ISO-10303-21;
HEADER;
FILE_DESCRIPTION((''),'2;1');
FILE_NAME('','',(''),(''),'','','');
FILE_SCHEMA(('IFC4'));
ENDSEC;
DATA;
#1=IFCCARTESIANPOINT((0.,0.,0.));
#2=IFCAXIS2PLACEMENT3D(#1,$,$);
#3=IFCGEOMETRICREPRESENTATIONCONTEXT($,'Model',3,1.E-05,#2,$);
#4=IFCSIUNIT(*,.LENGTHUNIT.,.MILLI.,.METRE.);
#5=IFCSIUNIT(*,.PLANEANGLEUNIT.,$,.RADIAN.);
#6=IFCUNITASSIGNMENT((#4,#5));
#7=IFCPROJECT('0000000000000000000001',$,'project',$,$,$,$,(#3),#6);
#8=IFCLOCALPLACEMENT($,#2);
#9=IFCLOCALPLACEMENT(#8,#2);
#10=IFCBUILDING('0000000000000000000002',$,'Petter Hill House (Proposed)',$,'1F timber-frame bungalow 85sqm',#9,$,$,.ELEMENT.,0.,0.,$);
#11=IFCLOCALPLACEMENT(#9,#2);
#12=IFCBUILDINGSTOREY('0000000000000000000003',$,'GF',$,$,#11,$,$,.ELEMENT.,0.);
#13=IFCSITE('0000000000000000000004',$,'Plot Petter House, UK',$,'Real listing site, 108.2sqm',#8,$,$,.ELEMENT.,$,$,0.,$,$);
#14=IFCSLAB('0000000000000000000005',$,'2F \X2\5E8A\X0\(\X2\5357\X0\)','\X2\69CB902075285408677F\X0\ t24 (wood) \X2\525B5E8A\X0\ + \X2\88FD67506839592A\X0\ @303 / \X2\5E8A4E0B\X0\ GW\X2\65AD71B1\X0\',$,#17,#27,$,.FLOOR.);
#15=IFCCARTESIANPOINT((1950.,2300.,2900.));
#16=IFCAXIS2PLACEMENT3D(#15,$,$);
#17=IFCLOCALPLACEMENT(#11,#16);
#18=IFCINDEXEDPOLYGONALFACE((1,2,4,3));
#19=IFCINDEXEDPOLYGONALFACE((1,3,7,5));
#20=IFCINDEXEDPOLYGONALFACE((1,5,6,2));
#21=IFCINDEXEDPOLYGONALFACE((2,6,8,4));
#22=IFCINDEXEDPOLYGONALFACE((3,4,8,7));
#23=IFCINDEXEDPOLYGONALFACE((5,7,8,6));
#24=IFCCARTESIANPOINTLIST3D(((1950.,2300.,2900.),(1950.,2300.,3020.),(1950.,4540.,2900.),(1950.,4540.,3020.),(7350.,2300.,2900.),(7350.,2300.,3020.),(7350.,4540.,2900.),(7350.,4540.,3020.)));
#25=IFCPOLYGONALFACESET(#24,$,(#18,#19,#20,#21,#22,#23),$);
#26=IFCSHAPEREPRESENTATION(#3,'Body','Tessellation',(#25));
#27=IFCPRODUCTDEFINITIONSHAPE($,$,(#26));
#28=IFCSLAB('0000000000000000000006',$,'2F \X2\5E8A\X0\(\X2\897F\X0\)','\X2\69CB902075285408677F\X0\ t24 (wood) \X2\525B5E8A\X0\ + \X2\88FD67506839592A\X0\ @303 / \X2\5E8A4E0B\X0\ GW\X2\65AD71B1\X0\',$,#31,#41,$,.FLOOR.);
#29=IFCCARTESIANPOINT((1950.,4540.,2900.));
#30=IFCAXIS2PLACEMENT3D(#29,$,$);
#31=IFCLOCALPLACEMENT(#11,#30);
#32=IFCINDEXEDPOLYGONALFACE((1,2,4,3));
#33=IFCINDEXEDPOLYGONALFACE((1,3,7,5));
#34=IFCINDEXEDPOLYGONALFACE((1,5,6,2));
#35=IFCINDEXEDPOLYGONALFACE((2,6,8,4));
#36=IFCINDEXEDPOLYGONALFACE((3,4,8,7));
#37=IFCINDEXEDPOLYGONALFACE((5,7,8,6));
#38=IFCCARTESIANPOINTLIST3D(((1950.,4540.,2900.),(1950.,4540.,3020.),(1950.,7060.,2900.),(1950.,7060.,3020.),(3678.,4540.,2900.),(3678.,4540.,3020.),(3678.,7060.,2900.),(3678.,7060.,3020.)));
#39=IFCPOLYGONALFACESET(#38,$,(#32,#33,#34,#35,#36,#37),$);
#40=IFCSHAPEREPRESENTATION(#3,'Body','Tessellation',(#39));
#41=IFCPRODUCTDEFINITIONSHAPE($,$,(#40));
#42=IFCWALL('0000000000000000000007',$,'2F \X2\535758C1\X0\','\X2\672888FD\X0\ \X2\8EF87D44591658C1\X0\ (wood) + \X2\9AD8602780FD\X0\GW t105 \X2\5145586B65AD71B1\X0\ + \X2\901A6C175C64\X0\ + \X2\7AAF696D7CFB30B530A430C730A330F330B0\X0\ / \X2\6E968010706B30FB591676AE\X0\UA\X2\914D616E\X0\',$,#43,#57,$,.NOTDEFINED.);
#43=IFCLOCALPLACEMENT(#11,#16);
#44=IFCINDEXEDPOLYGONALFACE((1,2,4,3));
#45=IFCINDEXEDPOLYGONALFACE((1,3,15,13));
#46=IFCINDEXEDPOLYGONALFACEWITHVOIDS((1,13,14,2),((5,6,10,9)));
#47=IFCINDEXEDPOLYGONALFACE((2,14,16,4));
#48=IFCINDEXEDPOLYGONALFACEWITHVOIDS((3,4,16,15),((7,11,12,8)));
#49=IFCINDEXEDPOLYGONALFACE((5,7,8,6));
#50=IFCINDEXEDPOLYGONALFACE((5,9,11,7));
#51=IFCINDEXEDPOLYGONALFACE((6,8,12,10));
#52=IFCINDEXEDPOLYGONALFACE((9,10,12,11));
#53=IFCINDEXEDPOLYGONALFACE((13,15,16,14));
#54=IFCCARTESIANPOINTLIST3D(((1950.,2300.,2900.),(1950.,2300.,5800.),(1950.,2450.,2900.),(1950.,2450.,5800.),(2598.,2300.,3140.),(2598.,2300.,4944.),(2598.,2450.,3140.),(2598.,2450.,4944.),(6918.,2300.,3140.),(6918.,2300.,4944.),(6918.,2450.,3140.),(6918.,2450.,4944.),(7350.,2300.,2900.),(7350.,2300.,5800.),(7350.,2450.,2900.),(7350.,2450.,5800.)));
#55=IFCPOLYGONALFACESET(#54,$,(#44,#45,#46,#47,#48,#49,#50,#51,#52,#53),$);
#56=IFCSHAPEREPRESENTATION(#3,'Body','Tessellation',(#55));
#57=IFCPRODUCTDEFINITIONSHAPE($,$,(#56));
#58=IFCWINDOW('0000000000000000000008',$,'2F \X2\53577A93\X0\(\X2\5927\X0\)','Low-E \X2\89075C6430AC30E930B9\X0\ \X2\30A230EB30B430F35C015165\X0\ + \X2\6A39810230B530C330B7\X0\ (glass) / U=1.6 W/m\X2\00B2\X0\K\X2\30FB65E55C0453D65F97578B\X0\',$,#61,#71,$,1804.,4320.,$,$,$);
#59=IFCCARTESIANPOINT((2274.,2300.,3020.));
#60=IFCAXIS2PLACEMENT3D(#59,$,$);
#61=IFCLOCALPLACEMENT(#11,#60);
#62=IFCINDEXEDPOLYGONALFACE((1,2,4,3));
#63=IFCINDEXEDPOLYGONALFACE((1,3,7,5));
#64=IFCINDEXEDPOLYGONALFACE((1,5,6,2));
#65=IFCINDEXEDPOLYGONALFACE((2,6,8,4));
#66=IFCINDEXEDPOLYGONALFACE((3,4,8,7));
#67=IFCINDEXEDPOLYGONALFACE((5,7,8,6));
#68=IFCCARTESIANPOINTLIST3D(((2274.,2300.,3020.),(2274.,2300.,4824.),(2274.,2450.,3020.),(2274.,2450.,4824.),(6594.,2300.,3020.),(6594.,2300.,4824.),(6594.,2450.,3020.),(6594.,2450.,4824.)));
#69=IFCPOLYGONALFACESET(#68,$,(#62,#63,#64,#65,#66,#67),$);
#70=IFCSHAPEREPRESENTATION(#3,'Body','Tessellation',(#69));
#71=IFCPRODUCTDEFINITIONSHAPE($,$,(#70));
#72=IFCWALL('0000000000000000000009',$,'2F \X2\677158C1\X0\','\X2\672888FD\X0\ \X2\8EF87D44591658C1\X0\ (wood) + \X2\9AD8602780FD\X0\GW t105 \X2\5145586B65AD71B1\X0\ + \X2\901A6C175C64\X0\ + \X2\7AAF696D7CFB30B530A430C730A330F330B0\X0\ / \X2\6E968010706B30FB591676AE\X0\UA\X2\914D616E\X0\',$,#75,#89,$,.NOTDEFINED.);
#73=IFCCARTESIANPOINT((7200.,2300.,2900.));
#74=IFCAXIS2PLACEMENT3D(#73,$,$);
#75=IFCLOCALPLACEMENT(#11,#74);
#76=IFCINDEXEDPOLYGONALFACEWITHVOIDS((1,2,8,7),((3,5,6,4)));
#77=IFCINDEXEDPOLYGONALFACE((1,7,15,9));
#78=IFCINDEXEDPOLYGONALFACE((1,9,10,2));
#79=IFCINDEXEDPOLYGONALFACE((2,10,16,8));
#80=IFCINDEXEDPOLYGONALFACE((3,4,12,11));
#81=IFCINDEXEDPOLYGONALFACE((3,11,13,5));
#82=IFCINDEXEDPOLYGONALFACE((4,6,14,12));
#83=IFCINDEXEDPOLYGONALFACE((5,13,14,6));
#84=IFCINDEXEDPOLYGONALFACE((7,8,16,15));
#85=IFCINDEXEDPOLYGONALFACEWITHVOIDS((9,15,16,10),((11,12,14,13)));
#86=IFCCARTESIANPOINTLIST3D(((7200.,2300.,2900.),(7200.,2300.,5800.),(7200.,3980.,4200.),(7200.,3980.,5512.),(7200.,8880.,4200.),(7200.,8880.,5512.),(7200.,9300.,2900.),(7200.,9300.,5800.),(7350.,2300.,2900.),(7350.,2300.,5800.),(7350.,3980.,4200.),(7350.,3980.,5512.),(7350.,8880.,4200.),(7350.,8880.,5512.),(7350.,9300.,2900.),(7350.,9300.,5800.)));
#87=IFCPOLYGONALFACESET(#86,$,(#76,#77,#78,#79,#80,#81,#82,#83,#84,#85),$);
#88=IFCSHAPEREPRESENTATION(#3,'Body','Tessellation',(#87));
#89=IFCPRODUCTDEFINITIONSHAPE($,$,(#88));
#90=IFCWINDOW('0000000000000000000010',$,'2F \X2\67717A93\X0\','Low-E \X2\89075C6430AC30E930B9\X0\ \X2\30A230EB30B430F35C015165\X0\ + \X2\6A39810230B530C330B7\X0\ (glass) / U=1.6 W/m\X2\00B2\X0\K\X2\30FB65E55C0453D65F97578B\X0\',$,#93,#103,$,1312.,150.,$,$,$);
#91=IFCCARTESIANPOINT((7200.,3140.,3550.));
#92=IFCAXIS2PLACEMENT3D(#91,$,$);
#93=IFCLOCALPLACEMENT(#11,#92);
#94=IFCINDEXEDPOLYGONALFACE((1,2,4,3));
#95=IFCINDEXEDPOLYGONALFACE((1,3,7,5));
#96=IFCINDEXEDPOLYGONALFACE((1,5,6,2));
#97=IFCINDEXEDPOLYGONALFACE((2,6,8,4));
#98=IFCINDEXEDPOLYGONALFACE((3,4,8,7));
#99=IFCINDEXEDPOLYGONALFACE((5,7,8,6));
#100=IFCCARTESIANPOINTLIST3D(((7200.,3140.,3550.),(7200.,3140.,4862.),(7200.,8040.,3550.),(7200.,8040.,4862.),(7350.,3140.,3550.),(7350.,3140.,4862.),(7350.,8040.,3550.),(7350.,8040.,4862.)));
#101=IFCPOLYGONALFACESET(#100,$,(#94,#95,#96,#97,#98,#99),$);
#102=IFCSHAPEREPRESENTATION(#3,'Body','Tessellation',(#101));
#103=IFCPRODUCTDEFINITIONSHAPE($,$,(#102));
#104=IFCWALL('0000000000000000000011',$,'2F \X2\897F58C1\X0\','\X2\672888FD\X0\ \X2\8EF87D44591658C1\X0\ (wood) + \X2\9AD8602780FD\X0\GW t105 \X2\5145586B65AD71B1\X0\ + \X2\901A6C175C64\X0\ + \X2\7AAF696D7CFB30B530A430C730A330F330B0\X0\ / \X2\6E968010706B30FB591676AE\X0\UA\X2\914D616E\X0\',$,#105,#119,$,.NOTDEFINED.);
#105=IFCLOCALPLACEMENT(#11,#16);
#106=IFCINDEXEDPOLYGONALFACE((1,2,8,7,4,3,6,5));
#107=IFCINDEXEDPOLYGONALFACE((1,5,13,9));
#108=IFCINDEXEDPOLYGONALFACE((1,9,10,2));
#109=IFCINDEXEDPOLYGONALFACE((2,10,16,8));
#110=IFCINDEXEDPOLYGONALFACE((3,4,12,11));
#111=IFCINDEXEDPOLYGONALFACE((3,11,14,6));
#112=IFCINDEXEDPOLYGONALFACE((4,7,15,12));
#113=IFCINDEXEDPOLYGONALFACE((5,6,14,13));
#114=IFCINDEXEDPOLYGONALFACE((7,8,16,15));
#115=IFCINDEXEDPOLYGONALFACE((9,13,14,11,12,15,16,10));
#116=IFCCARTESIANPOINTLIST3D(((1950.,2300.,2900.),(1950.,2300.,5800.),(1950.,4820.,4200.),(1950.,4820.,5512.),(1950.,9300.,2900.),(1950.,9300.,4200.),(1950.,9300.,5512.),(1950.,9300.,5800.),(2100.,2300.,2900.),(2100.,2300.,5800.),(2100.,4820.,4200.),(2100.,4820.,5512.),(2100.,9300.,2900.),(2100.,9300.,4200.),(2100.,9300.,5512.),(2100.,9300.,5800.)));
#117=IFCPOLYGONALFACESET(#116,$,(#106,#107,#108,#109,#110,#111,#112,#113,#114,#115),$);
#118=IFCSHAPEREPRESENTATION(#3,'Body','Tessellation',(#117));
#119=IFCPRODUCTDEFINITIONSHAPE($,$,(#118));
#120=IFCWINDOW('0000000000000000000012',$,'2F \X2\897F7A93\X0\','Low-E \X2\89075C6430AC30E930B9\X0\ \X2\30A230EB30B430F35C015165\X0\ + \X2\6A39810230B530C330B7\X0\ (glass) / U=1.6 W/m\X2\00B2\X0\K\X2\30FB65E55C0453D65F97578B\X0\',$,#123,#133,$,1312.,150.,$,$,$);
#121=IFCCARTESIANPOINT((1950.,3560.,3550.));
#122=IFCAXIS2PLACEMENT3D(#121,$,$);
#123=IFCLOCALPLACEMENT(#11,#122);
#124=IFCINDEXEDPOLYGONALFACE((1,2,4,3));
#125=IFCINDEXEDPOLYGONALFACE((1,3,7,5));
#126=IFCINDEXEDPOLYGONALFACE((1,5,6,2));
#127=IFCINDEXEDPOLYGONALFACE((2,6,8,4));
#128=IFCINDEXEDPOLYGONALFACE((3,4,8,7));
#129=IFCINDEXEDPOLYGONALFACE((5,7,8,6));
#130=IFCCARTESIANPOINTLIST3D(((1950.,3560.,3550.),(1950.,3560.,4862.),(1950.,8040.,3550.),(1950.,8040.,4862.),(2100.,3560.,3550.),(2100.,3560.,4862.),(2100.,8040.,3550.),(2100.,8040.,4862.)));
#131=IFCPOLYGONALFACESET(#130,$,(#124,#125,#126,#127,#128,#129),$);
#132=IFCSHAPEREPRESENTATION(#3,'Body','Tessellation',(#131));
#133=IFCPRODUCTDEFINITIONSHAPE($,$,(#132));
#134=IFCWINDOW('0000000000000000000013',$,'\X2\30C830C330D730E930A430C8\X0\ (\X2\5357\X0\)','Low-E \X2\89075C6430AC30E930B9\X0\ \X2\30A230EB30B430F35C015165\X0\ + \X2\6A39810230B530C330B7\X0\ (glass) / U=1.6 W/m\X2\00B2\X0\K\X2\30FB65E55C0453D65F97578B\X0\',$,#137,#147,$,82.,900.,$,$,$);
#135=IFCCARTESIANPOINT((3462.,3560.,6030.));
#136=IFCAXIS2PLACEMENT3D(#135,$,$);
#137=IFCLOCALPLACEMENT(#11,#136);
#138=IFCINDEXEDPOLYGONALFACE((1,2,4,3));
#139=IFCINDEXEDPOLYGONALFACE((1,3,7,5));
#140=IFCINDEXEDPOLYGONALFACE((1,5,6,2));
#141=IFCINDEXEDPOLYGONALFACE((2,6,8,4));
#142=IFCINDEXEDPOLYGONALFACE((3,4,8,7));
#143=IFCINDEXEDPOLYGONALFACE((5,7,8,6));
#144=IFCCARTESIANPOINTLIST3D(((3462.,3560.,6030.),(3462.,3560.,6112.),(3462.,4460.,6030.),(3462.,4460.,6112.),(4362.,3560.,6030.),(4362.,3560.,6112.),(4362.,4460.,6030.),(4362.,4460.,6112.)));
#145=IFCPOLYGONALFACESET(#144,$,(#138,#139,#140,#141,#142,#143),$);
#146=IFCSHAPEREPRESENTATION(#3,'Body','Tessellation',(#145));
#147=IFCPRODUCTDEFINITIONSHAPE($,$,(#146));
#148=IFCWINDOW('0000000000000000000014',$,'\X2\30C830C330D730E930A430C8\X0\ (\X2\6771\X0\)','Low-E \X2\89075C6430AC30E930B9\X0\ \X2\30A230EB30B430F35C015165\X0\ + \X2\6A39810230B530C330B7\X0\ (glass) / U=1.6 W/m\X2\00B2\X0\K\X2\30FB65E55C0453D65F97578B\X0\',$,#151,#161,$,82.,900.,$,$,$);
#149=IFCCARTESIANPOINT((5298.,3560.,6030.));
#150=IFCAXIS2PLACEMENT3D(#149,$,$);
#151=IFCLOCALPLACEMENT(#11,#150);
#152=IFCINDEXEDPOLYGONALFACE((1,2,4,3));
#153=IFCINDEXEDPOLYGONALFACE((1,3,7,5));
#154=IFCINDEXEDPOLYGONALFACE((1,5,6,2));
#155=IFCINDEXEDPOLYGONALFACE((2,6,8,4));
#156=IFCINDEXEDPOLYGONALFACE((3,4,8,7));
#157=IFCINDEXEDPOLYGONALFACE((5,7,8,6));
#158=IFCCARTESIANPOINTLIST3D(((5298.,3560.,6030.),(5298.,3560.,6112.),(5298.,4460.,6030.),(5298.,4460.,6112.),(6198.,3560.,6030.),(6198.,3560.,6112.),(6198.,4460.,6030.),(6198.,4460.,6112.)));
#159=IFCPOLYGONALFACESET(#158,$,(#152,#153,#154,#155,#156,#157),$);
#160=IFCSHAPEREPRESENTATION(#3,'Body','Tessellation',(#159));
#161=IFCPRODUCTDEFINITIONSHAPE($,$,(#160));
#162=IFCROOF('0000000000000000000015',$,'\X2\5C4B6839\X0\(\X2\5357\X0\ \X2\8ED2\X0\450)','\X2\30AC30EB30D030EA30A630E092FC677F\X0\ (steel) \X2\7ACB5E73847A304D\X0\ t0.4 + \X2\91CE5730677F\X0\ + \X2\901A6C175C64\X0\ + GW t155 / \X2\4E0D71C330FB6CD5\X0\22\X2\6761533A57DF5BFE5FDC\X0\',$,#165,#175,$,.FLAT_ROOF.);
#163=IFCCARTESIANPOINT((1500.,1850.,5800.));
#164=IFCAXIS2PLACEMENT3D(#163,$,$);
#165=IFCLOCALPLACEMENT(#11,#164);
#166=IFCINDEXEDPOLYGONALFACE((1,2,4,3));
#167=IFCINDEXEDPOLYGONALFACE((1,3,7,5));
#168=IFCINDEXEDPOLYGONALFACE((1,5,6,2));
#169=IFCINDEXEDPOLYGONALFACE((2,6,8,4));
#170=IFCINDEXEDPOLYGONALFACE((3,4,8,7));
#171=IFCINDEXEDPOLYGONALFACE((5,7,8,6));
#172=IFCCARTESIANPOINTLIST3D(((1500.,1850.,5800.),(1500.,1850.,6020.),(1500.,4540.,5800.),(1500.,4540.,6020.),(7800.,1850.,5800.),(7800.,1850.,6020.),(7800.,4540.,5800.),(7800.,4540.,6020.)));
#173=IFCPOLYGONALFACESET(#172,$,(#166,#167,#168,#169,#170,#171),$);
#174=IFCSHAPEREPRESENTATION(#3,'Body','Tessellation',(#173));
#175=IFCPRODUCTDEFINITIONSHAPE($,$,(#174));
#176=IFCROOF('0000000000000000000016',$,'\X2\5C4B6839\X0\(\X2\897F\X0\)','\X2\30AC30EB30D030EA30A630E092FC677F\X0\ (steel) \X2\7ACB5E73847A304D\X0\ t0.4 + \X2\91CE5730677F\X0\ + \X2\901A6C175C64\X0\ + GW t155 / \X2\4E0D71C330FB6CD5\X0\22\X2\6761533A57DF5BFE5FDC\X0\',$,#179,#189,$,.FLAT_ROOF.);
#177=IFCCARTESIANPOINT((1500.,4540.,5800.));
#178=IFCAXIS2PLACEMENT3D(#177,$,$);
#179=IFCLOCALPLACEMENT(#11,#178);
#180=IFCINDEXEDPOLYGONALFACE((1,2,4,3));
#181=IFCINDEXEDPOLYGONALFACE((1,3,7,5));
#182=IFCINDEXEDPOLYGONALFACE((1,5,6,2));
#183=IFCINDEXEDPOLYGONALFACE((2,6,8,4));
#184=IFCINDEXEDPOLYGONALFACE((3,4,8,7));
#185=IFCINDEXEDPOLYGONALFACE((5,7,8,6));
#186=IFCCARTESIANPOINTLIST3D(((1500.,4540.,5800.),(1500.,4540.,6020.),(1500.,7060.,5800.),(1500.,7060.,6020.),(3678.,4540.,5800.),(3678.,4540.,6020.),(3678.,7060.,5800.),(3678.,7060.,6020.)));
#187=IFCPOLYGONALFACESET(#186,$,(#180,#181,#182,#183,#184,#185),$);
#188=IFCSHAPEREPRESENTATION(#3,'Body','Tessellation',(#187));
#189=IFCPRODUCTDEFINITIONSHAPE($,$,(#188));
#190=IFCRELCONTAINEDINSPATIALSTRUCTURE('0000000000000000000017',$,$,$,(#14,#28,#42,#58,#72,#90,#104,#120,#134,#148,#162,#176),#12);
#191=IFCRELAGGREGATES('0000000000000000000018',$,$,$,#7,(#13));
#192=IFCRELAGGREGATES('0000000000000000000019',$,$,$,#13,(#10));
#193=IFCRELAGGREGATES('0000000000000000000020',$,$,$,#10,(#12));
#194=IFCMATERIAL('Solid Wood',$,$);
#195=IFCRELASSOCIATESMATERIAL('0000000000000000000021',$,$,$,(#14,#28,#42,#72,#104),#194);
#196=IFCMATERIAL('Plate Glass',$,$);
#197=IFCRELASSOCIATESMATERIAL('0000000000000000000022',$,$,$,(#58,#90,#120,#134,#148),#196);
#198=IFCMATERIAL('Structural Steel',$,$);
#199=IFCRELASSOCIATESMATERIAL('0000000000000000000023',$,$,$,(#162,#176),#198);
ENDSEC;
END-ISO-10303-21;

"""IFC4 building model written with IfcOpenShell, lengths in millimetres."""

from ifc_helpers import new_model, si_unit, frame, frame_2d, origin, place, context, project, spatial, rectangle, extrude, material, element, fill, save


model = new_model("IFC4")

# Units and contexts
model_context = context("Model", 3, precision=1e-05, world=origin())
ifc_project = project(units=[si_unit("LENGTHUNIT", "METRE", prefix="MILLI"), si_unit("PLANEANGLEUNIT", "RADIAN")], contexts=[model_context])

# Site, building, storey
site_placement = place(None, origin())
site = spatial("IfcSite", under=ifc_project, at=site_placement, Name="Plot Petter House, UK", ObjectType="Real listing site, 108.2sqm", CompositionType="ELEMENT", RefElevation=0.0)
building_placement = place(site_placement, origin())
building = spatial("IfcBuilding", under=site, at=building_placement, Name="Petter Hill House (Proposed)", ObjectType="1F timber-frame bungalow 85sqm", CompositionType="ELEMENT", ElevationOfRefHeight=0.0, ElevationOfTerrain=0.0)
storey_placement = place(building_placement, origin())
storey = spatial("IfcBuildingStorey", under=building, at=storey_placement, Name="GF", CompositionType="ELEMENT", Elevation=0.0)

# Slabs
ifc_material_1 = material(Name="Solid Wood")
slab_1_placement = place(storey_placement, frame((1950.0, 2300.0, 2900.0)))
element("IfcSlab", 1, at=slab_1_placement, inside=storey, material=ifc_material_1, Name="2F 床(南)", Description="構造用合板 t24 (wood) 剛床 + 製材根太 @303 / 床下 GW断熱", PredefinedType="FLOOR", context=model_context, shape_type="SweptSolid", body=[
    extrude(rectangle(XDim=5400.0, YDim=2240.0, at=frame_2d((2700.0, 1120.0))), frame((1950.0, 2300.0, 2900.0)), (0.0, 0.0, 1.0), 120.0),
])
slab_2_placement = place(storey_placement, frame((1950.0, 4540.0, 2900.0)))
element("IfcSlab", 2, at=slab_2_placement, inside=storey, material=ifc_material_1, Name="2F 床(西)", Description="構造用合板 t24 (wood) 剛床 + 製材根太 @303 / 床下 GW断熱", PredefinedType="FLOOR", context=model_context, shape_type="SweptSolid", body=[
    extrude(rectangle(XDim=1728.0, YDim=2520.0, at=frame_2d((864.0, 1260.0))), frame((1950.0, 4540.0, 2900.0)), (0.0, 0.0, 1.0), 120.0),
])

# Walls, openings, windows
wall_1_placement = place(storey_placement, frame((1950.0, 2300.0, 2900.0)))
wall_1 = element("IfcWall", 3, at=wall_1_placement, inside=storey, material=ifc_material_1, Name="2F 南壁", Description="木製 軸組外壁 (wood) + 高性能GW t105 充填断熱 + 通気層 + 窯業系サイディング / 準耐火・外皮UA配慮", PredefinedType="NOTDEFINED", context=model_context, shape_type="SweptSolid", body=[
    extrude(rectangle(XDim=5400.0, YDim=150.0, at=frame_2d((2700.0, 75.0))), frame((1950.0, 2300.0, 2900.0)), (0.0, 0.0, 1.0), 2900.0),
])
opening_1_placement = place(storey_placement, frame((2274.0, 2300.0, 3020.0)))
opening_1 = element("IfcOpeningElement", 4, at=opening_1_placement, cuts=wall_1, PredefinedType="NOTDEFINED", context=model_context, shape_type="SweptSolid", body=[
    extrude(rectangle(XDim=4320.0, YDim=150.0, at=frame_2d((2160.0, 75.0))), frame((2274.0, 2300.0, 3020.0)), (0.0, 0.0, 1.0), 1804.0),
])
ifc_material_2 = material(Name="Plate Glass")
window_1_placement = place(storey_placement, frame((2274.0, 2300.0, 3020.0)))
window_1 = element("IfcWindow", 5, at=window_1_placement, inside=storey, material=ifc_material_2, Name="2F 南窓(大)", Description="Low-E 複層ガラス アルゴン封入 + 樹脂サッシ (glass) / U=1.6 W/m²K・日射取得型", OverallHeight=1804.0, OverallWidth=4320.0, context=model_context, shape_type="SweptSolid", body=[
    extrude(rectangle(XDim=4320.0, YDim=150.0, at=frame_2d((2160.0, 75.0))), frame((2274.0, 2300.0, 3020.0)), (0.0, 0.0, 1.0), 1804.0),
])
fill(opening_1, window_1)
wall_2_placement = place(storey_placement, frame((7200.0, 2300.0, 2900.0)))
wall_2 = element("IfcWall", 6, at=wall_2_placement, inside=storey, material=ifc_material_1, Name="2F 東壁", Description="木製 軸組外壁 (wood) + 高性能GW t105 充填断熱 + 通気層 + 窯業系サイディング / 準耐火・外皮UA配慮", PredefinedType="NOTDEFINED", context=model_context, shape_type="SweptSolid", body=[
    extrude(rectangle(XDim=150.0, YDim=7000.0, at=frame_2d((75.0, 3500.0))), frame((7200.0, 2300.0, 2900.0)), (0.0, 0.0, 1.0), 2900.0),
])
opening_2_placement = place(storey_placement, frame((7200.0, 3140.0, 3550.0)))
opening_2 = element("IfcOpeningElement", 7, at=opening_2_placement, cuts=wall_2, PredefinedType="NOTDEFINED", context=model_context, shape_type="SweptSolid", body=[
    extrude(rectangle(XDim=150.0, YDim=4900.0, at=frame_2d((75.0, 2450.0))), frame((7200.0, 3140.0, 3550.0)), (0.0, 0.0, 1.0), 1312.0),
])
window_2_placement = place(storey_placement, frame((7200.0, 3140.0, 3550.0)))
window_2 = element("IfcWindow", 8, at=window_2_placement, inside=storey, material=ifc_material_2, Name="2F 東窓", Description="Low-E 複層ガラス アルゴン封入 + 樹脂サッシ (glass) / U=1.6 W/m²K・日射取得型", OverallHeight=1312.0, OverallWidth=150.0, context=model_context, shape_type="SweptSolid", body=[
    extrude(rectangle(XDim=150.0, YDim=4900.0, at=frame_2d((75.0, 2450.0))), frame((7200.0, 3140.0, 3550.0)), (0.0, 0.0, 1.0), 1312.0),
])
fill(opening_2, window_2)
wall_3_placement = place(storey_placement, frame((1950.0, 2300.0, 2900.0)))
wall_3 = element("IfcWall", 9, at=wall_3_placement, inside=storey, material=ifc_material_1, Name="2F 西壁", Description="木製 軸組外壁 (wood) + 高性能GW t105 充填断熱 + 通気層 + 窯業系サイディング / 準耐火・外皮UA配慮", PredefinedType="NOTDEFINED", context=model_context, shape_type="SweptSolid", body=[
    extrude(rectangle(XDim=150.0, YDim=7000.0, at=frame_2d((75.0, 3500.0))), frame((1950.0, 2300.0, 2900.0)), (0.0, 0.0, 1.0), 2900.0),
])
opening_3_placement = place(storey_placement, frame((1950.0, 3560.0, 3550.0)))
opening_3 = element("IfcOpeningElement", 10, at=opening_3_placement, cuts=wall_3, PredefinedType="NOTDEFINED", context=model_context, shape_type="SweptSolid", body=[
    extrude(rectangle(XDim=150.0, YDim=4480.0, at=frame_2d((75.0, 2240.0))), frame((1950.0, 3560.0, 3550.0)), (0.0, 0.0, 1.0), 1312.0),
])
window_3_placement = place(storey_placement, frame((1950.0, 3560.0, 3550.0)))
window_3 = element("IfcWindow", 11, at=window_3_placement, inside=storey, material=ifc_material_2, Name="2F 西窓", Description="Low-E 複層ガラス アルゴン封入 + 樹脂サッシ (glass) / U=1.6 W/m²K・日射取得型", OverallHeight=1312.0, OverallWidth=150.0, context=model_context, shape_type="SweptSolid", body=[
    extrude(rectangle(XDim=150.0, YDim=4480.0, at=frame_2d((75.0, 2240.0))), frame((1950.0, 3560.0, 3550.0)), (0.0, 0.0, 1.0), 1312.0),
])
fill(opening_3, window_3)

# Windows
window_4_placement = place(storey_placement, frame((3462.0, 3560.0, 6030.0)))
element("IfcWindow", 12, at=window_4_placement, inside=storey, material=ifc_material_2, Name="トップライト (南)", Description="Low-E 複層ガラス アルゴン封入 + 樹脂サッシ (glass) / U=1.6 W/m²K・日射取得型", OverallHeight=82.0, OverallWidth=900.0, context=model_context, shape_type="SweptSolid", body=[
    extrude(rectangle(XDim=900.0, YDim=900.0, at=frame_2d((450.0, 450.0))), frame((3462.0, 3560.0, 6030.0)), (0.0, 0.0, 1.0), 82.0),
])
window_5_placement = place(storey_placement, frame((5298.0, 3560.0, 6030.0)))
element("IfcWindow", 13, at=window_5_placement, inside=storey, material=ifc_material_2, Name="トップライト (東)", Description="Low-E 複層ガラス アルゴン封入 + 樹脂サッシ (glass) / U=1.6 W/m²K・日射取得型", OverallHeight=82.0, OverallWidth=900.0, context=model_context, shape_type="SweptSolid", body=[
    extrude(rectangle(XDim=900.0, YDim=900.0, at=frame_2d((450.0, 450.0))), frame((5298.0, 3560.0, 6030.0)), (0.0, 0.0, 1.0), 82.0),
])

# Roofs
ifc_material_3 = material(Name="Structural Steel")
roof_1_placement = place(storey_placement, frame((1500.0, 1850.0, 5800.0)))
element("IfcRoof", 14, at=roof_1_placement, inside=storey, material=ifc_material_3, Name="屋根(南 軒450)", Description="ガルバリウム鋼板 (steel) 立平葺き t0.4 + 野地板 + 通気層 + GW t155 / 不燃・法22条区域対応", PredefinedType="FLAT_ROOF", context=model_context, shape_type="SweptSolid", body=[
    extrude(rectangle(XDim=6300.0, YDim=2690.0, at=frame_2d((3150.0, 1345.0))), frame((1500.0, 1850.0, 5800.0)), (0.0, 0.0, 1.0), 220.0),
])
roof_2_placement = place(storey_placement, frame((1500.0, 4540.0, 5800.0)))
element("IfcRoof", 15, at=roof_2_placement, inside=storey, material=ifc_material_3, Name="屋根(西)", Description="ガルバリウム鋼板 (steel) 立平葺き t0.4 + 野地板 + 通気層 + GW t155 / 不燃・法22条区域対応", PredefinedType="FLAT_ROOF", context=model_context, shape_type="SweptSolid", body=[
    extrude(rectangle(XDim=2178.0, YDim=2520.0, at=frame_2d((1089.0, 1260.0))), frame((1500.0, 4540.0, 5800.0)), (0.0, 0.0, 1.0), 220.0),
])

save(model, "model.ifc")
